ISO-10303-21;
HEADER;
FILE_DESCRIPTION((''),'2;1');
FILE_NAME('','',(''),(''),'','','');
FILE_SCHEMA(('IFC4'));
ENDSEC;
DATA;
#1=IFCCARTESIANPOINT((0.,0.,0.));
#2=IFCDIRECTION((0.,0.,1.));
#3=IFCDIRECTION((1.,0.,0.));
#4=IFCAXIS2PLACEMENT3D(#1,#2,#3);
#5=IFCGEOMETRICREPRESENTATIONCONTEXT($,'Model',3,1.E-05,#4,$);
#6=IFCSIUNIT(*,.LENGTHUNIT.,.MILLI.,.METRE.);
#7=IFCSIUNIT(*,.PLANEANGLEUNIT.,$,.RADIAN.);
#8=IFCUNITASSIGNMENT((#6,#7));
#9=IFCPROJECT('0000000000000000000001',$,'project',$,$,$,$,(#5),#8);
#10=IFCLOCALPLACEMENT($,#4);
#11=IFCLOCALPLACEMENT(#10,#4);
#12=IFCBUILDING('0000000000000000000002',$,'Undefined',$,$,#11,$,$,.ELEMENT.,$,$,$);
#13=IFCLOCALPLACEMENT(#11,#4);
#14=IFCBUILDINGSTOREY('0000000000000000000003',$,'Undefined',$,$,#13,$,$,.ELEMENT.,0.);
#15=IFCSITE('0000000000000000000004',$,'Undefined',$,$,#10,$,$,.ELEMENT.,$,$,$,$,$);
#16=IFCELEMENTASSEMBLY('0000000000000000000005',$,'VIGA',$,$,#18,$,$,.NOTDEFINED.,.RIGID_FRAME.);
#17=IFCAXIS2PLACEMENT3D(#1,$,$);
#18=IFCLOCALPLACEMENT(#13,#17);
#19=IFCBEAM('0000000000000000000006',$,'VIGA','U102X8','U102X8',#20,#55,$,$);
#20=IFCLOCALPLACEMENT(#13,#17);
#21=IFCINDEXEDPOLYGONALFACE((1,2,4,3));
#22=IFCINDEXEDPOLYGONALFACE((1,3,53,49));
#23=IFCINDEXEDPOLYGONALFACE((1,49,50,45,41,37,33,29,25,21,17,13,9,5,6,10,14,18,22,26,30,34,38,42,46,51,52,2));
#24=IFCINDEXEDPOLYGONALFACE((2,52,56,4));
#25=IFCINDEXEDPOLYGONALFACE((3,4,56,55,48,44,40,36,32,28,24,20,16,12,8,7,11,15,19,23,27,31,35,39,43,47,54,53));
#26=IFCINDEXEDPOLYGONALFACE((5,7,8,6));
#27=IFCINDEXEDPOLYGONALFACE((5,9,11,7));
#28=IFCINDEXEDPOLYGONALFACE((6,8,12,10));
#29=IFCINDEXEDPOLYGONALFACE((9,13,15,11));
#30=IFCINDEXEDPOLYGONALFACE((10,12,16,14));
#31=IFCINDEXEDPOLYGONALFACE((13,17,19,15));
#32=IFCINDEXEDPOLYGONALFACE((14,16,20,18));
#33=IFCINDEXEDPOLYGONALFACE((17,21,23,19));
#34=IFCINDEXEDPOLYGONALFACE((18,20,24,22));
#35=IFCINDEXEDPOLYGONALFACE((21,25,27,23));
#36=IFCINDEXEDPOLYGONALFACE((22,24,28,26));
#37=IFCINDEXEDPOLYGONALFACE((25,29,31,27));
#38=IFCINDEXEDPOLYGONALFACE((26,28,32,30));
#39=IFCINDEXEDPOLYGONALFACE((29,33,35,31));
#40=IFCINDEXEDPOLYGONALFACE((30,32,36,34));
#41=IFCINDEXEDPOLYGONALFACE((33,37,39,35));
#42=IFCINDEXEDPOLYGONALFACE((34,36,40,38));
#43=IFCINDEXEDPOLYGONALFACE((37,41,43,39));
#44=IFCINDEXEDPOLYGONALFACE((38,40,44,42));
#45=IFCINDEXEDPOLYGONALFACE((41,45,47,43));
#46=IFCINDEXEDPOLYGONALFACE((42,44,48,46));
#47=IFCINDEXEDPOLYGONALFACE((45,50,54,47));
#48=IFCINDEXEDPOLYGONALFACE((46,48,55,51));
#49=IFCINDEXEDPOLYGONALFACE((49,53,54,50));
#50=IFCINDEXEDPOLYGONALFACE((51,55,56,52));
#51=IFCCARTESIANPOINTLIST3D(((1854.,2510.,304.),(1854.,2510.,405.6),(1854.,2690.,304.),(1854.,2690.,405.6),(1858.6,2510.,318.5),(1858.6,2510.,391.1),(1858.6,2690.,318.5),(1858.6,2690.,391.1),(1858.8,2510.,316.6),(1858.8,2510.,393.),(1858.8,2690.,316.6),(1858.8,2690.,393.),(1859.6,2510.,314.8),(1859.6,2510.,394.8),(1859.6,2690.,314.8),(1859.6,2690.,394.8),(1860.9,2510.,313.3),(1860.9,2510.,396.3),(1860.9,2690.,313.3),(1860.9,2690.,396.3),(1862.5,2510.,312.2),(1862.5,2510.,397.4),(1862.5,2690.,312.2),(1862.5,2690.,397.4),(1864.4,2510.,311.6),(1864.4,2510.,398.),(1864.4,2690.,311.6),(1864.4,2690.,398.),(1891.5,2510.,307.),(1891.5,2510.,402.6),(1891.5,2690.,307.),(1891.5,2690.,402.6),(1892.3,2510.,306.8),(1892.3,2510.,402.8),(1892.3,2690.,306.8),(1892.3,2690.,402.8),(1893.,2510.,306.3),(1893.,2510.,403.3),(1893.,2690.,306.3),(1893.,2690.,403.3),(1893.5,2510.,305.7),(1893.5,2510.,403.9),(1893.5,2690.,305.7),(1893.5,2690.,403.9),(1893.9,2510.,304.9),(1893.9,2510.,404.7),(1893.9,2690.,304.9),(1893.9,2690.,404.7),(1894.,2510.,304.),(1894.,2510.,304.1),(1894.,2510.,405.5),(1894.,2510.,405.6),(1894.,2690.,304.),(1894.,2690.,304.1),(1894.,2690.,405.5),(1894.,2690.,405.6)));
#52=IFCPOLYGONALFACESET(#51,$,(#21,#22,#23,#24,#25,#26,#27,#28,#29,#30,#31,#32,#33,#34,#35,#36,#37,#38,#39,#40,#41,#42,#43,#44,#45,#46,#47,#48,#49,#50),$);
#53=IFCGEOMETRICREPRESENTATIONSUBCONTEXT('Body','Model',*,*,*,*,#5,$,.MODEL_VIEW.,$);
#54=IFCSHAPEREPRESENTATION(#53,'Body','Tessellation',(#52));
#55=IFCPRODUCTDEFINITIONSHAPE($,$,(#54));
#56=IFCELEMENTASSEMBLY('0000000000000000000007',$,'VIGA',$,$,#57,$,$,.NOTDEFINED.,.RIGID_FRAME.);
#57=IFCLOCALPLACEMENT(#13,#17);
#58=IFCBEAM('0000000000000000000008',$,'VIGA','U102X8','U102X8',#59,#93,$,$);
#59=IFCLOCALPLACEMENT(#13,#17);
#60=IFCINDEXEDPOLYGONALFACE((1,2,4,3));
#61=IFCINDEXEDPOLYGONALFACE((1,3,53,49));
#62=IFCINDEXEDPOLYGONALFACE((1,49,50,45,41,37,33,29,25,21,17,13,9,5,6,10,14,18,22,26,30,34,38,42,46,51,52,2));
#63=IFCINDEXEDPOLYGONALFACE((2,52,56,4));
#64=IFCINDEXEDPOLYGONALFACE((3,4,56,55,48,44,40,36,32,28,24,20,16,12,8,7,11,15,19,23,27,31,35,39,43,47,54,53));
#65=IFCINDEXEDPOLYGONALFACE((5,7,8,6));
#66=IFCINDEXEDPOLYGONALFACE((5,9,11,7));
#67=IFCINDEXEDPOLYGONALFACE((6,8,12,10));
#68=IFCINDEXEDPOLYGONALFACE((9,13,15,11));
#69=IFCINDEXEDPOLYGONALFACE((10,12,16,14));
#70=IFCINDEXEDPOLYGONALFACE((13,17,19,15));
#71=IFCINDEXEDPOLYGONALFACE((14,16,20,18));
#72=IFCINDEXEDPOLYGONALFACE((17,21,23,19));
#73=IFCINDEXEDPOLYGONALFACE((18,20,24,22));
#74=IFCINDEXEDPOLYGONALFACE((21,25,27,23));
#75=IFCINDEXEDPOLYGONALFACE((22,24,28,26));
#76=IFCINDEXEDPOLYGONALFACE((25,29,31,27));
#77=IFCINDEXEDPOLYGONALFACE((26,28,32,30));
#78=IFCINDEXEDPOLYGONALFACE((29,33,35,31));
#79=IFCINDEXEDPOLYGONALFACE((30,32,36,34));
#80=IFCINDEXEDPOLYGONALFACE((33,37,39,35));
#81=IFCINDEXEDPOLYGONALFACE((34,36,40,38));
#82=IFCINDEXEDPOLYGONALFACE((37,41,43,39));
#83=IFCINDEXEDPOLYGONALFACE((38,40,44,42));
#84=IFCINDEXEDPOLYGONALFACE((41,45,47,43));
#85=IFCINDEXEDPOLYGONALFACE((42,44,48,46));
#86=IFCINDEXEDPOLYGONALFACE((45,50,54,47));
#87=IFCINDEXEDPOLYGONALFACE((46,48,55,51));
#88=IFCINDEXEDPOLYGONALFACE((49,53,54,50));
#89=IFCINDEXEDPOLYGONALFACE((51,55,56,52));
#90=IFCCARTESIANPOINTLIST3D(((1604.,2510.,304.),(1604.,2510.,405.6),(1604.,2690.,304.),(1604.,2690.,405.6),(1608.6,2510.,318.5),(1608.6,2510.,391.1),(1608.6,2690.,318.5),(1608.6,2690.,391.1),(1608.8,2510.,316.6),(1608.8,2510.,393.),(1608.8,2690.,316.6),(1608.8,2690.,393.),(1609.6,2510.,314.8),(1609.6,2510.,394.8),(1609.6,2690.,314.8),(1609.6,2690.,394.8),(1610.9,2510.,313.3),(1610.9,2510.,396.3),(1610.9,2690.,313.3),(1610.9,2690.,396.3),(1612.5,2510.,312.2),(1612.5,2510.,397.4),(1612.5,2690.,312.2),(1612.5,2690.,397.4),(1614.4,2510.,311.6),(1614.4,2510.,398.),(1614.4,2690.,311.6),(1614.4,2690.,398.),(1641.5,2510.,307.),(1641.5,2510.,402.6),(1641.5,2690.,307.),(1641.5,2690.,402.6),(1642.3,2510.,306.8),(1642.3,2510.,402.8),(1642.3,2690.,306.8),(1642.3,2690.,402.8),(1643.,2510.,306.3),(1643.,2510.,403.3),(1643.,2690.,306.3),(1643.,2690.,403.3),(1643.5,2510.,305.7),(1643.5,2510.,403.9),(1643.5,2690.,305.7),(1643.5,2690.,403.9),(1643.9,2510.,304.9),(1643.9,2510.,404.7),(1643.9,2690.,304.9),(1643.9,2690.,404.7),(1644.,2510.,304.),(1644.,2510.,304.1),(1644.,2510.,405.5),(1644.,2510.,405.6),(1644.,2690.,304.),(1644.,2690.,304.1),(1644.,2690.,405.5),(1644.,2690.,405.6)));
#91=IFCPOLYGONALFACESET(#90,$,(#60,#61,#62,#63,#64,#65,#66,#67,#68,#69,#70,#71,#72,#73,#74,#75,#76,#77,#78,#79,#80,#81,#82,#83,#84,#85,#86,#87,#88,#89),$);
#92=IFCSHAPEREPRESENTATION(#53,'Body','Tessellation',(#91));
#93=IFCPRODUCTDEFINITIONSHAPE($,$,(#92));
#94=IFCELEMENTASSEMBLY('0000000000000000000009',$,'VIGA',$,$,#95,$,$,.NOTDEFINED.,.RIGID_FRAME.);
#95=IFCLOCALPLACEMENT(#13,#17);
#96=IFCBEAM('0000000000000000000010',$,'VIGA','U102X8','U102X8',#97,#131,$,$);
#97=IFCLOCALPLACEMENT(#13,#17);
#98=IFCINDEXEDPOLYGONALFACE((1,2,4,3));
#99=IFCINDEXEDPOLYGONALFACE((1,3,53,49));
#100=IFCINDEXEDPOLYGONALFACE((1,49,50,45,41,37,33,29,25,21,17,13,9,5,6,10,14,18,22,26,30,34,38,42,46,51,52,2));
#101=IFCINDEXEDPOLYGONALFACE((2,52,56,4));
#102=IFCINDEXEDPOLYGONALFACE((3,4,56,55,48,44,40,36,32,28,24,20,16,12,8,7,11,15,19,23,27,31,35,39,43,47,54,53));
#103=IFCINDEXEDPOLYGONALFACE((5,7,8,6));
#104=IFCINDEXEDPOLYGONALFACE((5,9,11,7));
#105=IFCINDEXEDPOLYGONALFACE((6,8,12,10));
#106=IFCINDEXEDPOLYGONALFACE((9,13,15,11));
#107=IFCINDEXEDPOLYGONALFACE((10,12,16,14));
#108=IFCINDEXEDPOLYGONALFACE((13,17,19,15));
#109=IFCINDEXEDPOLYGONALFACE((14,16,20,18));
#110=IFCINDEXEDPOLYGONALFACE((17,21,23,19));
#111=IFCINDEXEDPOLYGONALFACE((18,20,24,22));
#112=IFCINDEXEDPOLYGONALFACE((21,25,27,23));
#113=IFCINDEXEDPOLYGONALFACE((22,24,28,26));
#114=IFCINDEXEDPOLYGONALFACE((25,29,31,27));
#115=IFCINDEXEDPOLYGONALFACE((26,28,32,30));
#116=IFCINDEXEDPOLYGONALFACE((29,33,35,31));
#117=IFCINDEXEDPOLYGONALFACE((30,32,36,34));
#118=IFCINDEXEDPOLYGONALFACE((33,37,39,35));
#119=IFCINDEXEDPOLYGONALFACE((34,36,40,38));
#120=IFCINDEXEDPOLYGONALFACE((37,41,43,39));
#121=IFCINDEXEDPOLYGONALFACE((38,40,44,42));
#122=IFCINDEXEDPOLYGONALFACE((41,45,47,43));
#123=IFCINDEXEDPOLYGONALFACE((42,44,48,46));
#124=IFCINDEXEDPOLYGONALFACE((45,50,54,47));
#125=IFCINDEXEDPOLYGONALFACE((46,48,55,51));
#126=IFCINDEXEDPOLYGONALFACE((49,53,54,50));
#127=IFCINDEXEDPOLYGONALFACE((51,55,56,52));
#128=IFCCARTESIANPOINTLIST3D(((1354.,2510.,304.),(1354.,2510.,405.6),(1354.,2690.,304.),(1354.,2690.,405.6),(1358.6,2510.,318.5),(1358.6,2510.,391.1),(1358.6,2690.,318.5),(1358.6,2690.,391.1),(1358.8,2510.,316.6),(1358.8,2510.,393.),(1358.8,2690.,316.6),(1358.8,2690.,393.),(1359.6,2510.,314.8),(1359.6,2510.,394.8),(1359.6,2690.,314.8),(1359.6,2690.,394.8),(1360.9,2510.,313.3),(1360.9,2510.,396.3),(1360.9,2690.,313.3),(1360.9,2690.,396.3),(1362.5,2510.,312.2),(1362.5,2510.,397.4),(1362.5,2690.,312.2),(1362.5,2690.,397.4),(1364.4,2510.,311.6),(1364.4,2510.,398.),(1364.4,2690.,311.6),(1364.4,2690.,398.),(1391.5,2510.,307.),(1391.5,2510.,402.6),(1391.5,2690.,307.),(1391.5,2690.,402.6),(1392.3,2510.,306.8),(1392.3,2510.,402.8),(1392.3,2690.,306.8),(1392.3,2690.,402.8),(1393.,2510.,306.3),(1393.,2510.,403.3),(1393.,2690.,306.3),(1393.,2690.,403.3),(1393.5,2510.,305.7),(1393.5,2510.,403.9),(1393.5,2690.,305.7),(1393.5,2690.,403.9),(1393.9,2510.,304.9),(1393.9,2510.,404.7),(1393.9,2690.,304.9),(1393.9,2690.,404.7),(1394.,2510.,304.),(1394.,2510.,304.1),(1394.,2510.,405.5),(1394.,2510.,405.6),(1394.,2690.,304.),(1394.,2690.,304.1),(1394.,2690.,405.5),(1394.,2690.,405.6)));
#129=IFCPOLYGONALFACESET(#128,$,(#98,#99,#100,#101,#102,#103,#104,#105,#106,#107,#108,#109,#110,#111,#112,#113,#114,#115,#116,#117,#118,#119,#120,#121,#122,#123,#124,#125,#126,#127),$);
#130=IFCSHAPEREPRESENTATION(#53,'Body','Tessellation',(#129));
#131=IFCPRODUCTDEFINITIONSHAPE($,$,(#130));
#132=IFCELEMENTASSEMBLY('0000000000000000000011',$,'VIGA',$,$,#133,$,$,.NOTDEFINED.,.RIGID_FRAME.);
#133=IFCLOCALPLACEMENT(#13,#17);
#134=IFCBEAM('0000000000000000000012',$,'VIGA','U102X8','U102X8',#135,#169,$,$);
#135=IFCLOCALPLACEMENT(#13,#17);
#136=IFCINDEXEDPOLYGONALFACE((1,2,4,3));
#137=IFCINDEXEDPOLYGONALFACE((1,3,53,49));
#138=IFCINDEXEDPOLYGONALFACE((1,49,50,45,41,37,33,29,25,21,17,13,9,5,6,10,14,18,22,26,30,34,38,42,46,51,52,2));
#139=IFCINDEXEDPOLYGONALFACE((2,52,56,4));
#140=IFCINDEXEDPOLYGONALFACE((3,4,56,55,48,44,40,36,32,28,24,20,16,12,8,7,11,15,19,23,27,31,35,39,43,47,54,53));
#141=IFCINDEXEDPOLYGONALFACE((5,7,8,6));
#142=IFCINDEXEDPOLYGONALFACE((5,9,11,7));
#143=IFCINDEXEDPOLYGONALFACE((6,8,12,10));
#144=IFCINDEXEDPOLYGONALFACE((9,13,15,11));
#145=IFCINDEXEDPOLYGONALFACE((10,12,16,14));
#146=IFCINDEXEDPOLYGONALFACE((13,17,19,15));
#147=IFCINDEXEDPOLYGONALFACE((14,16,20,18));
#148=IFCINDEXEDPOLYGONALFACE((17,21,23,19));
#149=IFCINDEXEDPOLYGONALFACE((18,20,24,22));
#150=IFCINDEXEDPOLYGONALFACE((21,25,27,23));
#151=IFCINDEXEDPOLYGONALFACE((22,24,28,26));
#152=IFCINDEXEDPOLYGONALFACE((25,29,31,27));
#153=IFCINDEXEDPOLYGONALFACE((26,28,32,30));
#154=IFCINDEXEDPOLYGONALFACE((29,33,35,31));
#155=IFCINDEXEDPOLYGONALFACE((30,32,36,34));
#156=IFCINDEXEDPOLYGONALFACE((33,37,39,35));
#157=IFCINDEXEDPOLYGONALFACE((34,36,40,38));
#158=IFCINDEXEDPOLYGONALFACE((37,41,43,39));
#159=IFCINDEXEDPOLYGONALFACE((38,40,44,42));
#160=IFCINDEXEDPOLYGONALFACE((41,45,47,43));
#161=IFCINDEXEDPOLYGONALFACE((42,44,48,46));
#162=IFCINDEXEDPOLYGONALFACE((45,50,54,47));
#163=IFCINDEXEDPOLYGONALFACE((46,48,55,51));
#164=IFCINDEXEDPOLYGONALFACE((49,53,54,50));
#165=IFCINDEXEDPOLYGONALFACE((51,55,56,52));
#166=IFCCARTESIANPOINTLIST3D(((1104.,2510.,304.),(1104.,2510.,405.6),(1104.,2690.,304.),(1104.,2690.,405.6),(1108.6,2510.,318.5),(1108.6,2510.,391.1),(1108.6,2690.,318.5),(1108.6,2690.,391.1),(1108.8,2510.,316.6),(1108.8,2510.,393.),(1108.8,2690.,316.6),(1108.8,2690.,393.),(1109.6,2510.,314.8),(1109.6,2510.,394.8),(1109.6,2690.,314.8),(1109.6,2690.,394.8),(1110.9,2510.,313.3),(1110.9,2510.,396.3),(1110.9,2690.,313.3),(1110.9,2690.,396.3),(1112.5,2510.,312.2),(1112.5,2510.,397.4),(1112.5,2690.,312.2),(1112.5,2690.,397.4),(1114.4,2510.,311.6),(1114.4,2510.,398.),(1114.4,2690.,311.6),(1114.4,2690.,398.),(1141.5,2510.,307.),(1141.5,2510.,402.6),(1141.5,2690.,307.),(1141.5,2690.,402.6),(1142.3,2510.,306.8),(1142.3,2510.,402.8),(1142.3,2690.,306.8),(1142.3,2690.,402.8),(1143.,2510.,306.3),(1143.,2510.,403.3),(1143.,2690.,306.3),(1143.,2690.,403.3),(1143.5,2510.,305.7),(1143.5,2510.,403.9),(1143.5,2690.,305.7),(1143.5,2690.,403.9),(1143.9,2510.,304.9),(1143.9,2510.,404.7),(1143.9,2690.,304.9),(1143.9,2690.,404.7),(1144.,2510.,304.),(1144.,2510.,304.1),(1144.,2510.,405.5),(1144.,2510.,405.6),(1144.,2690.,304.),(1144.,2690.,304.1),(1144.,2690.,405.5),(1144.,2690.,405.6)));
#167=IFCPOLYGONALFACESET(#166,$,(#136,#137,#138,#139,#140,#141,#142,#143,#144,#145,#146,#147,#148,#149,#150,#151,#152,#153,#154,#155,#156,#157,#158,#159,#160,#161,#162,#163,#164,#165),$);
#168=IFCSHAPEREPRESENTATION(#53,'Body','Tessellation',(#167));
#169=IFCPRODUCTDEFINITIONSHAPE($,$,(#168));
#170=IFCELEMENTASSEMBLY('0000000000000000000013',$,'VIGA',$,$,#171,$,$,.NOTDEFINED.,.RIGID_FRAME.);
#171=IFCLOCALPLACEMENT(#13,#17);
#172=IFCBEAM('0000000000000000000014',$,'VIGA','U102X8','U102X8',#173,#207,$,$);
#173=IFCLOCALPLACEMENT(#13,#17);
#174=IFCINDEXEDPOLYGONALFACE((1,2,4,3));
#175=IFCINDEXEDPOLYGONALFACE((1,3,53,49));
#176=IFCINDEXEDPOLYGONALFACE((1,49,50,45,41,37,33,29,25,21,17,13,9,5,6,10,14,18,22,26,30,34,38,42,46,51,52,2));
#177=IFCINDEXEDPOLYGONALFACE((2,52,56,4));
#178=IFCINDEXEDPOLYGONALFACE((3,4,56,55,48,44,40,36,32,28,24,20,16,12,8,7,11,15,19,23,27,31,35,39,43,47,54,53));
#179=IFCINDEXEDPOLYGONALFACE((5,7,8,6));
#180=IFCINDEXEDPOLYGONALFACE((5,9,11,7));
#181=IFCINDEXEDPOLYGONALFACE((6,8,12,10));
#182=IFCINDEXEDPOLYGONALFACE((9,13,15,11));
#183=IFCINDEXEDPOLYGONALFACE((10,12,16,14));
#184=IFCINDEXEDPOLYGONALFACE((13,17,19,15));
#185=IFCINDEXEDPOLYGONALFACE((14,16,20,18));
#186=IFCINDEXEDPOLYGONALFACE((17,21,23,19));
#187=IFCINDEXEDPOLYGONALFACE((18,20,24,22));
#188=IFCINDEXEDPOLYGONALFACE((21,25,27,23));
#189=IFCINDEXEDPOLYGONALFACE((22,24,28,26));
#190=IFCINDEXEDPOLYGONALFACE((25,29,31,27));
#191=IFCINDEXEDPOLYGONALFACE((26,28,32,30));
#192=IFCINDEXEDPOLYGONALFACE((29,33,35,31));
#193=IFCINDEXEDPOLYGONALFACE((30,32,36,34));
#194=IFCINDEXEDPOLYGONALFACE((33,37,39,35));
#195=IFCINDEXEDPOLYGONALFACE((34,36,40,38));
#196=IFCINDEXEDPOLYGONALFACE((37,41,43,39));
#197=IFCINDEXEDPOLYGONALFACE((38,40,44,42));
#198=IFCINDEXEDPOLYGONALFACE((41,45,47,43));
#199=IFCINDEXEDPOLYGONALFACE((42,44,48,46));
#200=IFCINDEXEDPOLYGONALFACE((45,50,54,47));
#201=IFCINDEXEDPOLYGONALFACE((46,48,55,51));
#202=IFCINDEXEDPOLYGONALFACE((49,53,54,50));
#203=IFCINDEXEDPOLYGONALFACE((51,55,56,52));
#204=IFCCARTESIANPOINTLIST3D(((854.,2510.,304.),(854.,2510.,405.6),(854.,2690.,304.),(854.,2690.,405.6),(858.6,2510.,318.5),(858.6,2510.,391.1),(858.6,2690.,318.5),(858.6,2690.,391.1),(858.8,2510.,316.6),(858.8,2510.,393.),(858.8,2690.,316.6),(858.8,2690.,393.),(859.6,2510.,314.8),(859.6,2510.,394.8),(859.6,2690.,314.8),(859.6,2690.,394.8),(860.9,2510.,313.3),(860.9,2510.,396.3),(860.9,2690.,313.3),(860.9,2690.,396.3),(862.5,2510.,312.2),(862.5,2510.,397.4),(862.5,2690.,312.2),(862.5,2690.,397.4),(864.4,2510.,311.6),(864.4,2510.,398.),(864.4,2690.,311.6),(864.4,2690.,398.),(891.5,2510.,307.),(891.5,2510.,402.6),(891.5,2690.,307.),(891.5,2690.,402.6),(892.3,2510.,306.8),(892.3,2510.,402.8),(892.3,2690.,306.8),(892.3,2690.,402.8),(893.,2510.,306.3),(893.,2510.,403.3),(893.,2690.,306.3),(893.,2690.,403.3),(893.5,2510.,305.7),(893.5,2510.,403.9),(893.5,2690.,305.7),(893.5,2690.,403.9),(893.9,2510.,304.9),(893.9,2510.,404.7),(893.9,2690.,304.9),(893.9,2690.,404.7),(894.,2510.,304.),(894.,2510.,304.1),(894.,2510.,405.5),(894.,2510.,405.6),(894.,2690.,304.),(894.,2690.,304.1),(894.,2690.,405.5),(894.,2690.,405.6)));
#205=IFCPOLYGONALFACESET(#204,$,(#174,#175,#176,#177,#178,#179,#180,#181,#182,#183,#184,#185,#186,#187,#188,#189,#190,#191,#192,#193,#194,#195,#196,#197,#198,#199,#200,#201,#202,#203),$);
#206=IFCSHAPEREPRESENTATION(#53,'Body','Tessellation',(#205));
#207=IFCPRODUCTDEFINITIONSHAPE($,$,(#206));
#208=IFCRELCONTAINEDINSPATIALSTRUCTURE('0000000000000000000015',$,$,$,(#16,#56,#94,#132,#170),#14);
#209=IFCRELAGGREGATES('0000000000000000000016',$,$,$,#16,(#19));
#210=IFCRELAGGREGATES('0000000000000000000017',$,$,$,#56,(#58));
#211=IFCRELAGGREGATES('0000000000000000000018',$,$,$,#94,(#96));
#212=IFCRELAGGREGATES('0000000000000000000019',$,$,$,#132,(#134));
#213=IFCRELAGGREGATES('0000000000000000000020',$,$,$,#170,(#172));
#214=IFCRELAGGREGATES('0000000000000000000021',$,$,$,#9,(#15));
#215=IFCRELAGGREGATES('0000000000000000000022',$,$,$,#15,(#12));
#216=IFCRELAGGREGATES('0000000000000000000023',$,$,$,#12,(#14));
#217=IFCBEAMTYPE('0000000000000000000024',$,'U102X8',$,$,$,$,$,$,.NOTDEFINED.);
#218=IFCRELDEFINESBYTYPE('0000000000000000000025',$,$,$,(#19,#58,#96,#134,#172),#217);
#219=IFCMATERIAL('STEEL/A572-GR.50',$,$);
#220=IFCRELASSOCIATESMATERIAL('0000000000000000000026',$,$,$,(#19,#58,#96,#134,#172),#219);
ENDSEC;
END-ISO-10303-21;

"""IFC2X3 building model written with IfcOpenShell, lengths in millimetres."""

from ifc_helpers import new_model, si_unit, frame, origin_with_axes, origin_2d_with_axis, place, context, subcontext, project, spatial, u_section, extrude, material, type_object, element, aggregate, save


model = new_model("IFC2X3")

# Units and contexts
model_context = context("Model", 3, precision=1e-05, world=origin_with_axes())
body_context = subcontext(model_context, "Body", "Model", "MODEL_VIEW")
ifc_project = project(units=[si_unit("LENGTHUNIT", "METRE", prefix="MILLI"), si_unit("PLANEANGLEUNIT", "RADIAN")], contexts=[model_context])

# Site, building, storey
site_placement = place(None, origin_with_axes())
site = spatial("IfcSite", under=ifc_project, at=site_placement, Name="Undefined", CompositionType="ELEMENT")
building_placement = place(site_placement, origin_with_axes())
building = spatial("IfcBuilding", under=site, at=building_placement, Name="Undefined", CompositionType="ELEMENT")
storey_placement = place(building_placement, origin_with_axes())
storey = spatial("IfcBuildingStorey", under=building, at=storey_placement, Name="Undefined", CompositionType="ELEMENT", Elevation=0.0)

# Element assemblies, beams
assembly_1_placement = place(storey_placement, origin_with_axes())
assembly_1 = element("IfcElementAssembly", 1, at=assembly_1_placement, inside=storey, Name="VIGA", AssemblyPlace="NOTDEFINED", PredefinedType="RIGID_FRAME")
ifc_material_1 = material(Name="STEEL/A572-GR.50")
beam_type_1 = type_object("IfcBeamType", Name="U102X8", PredefinedType="NOTDEFINED")
beam_1_placement = place(assembly_1_placement, frame((1874.0, 2510.0, 354.8), z_axis=(0.0, 0.0, 1.0), x_axis=(0.0, 1.0, 0.0)))
beam_1 = element("IfcBeam", 2, at=beam_1_placement, type_object=beam_type_1, material=ifc_material_1, Name="VIGA", Description="U102X8", ObjectType="U102X8", context=body_context, shape_type="SweptSolid", body=[
    extrude(u_section(Depth=101.6, FlangeWidth=40.0, WebThickness=4.6, FlangeThickness=6.0, FilletRadius=7.0, EdgeRadius=3.0, FlangeSlope=0.16839, at=origin_2d_with_axis()), frame((180.0, 0.0, 0.0), z_axis=(-1.0, 0.0, 0.0), x_axis=(0.0, -1.0, 0.0)), (0.0, 0.0, 1.0), 180.0),
])
aggregate(assembly_1, [beam_1])
assembly_2_placement = place(storey_placement, origin_with_axes())
assembly_2 = element("IfcElementAssembly", 3, at=assembly_2_placement, inside=storey, Name="VIGA", AssemblyPlace="NOTDEFINED", PredefinedType="RIGID_FRAME")
beam_2_placement = place(assembly_2_placement, frame((1624.0, 2510.0, 354.8), z_axis=(0.0, 0.0, 1.0), x_axis=(0.0, 1.0, 0.0)))
beam_2 = element("IfcBeam", 4, at=beam_2_placement, type_object=beam_type_1, material=ifc_material_1, Name="VIGA", Description="U102X8", ObjectType="U102X8", context=body_context, shape_type="SweptSolid", body=[
    extrude(u_section(Depth=101.6, FlangeWidth=40.0, WebThickness=4.6, FlangeThickness=6.0, FilletRadius=7.0, EdgeRadius=3.0, FlangeSlope=0.16839, at=origin_2d_with_axis()), frame((180.0, 0.0, 0.0), z_axis=(-1.0, 0.0, 0.0), x_axis=(0.0, -1.0, 0.0)), (0.0, 0.0, 1.0), 180.0),
])
aggregate(assembly_2, [beam_2])
assembly_3_placement = place(storey_placement, origin_with_axes())
assembly_3 = element("IfcElementAssembly", 5, at=assembly_3_placement, inside=storey, Name="VIGA", AssemblyPlace="NOTDEFINED", PredefinedType="RIGID_FRAME")
beam_3_placement = place(assembly_3_placement, frame((1374.0, 2510.0, 354.8), z_axis=(0.0, 0.0, 1.0), x_axis=(0.0, 1.0, 0.0)))
beam_3 = element("IfcBeam", 6, at=beam_3_placement, type_object=beam_type_1, material=ifc_material_1, Name="VIGA", Description="U102X8", ObjectType="U102X8", context=body_context, shape_type="SweptSolid", body=[
    extrude(u_section(Depth=101.6, FlangeWidth=40.0, WebThickness=4.6, FlangeThickness=6.0, FilletRadius=7.0, EdgeRadius=3.0, FlangeSlope=0.16839, at=origin_2d_with_axis()), frame((180.0, 0.0, 0.0), z_axis=(-1.0, 0.0, 0.0), x_axis=(0.0, -1.0, 0.0)), (0.0, 0.0, 1.0), 180.0),
])
aggregate(assembly_3, [beam_3])
assembly_4_placement = place(storey_placement, origin_with_axes())
assembly_4 = element("IfcElementAssembly", 7, at=assembly_4_placement, inside=storey, Name="VIGA", AssemblyPlace="NOTDEFINED", PredefinedType="RIGID_FRAME")
beam_4_placement = place(assembly_4_placement, frame((1124.0, 2510.0, 354.8), z_axis=(0.0, 0.0, 1.0), x_axis=(0.0, 1.0, 0.0)))
beam_4 = element("IfcBeam", 8, at=beam_4_placement, type_object=beam_type_1, material=ifc_material_1, Name="VIGA", Description="U102X8", ObjectType="U102X8", context=body_context, shape_type="SweptSolid", body=[
    extrude(u_section(Depth=101.6, FlangeWidth=40.0, WebThickness=4.6, FlangeThickness=6.0, FilletRadius=7.0, EdgeRadius=3.0, FlangeSlope=0.16839, at=origin_2d_with_axis()), frame((180.0, 0.0, 0.0), z_axis=(-1.0, 0.0, 0.0), x_axis=(0.0, -1.0, 0.0)), (0.0, 0.0, 1.0), 180.0),
])
aggregate(assembly_4, [beam_4])
assembly_5_placement = place(storey_placement, origin_with_axes())
assembly_5 = element("IfcElementAssembly", 9, at=assembly_5_placement, inside=storey, Name="VIGA", AssemblyPlace="NOTDEFINED", PredefinedType="RIGID_FRAME")
beam_5_placement = place(assembly_5_placement, frame((874.0, 2510.0, 354.8), z_axis=(0.0, 0.0, 1.0), x_axis=(0.0, 1.0, 0.0)))
beam_5 = element("IfcBeam", 10, at=beam_5_placement, type_object=beam_type_1, material=ifc_material_1, Name="VIGA", Description="U102X8", ObjectType="U102X8", context=body_context, shape_type="SweptSolid", body=[
    extrude(u_section(Depth=101.6, FlangeWidth=40.0, WebThickness=4.6, FlangeThickness=6.0, FilletRadius=7.0, EdgeRadius=3.0, FlangeSlope=0.16839, at=origin_2d_with_axis()), frame((180.0, 0.0, 0.0), z_axis=(-1.0, 0.0, 0.0), x_axis=(0.0, -1.0, 0.0)), (0.0, 0.0, 1.0), 180.0),
])
aggregate(assembly_5, [beam_5])

save(model, "model.ifc")
